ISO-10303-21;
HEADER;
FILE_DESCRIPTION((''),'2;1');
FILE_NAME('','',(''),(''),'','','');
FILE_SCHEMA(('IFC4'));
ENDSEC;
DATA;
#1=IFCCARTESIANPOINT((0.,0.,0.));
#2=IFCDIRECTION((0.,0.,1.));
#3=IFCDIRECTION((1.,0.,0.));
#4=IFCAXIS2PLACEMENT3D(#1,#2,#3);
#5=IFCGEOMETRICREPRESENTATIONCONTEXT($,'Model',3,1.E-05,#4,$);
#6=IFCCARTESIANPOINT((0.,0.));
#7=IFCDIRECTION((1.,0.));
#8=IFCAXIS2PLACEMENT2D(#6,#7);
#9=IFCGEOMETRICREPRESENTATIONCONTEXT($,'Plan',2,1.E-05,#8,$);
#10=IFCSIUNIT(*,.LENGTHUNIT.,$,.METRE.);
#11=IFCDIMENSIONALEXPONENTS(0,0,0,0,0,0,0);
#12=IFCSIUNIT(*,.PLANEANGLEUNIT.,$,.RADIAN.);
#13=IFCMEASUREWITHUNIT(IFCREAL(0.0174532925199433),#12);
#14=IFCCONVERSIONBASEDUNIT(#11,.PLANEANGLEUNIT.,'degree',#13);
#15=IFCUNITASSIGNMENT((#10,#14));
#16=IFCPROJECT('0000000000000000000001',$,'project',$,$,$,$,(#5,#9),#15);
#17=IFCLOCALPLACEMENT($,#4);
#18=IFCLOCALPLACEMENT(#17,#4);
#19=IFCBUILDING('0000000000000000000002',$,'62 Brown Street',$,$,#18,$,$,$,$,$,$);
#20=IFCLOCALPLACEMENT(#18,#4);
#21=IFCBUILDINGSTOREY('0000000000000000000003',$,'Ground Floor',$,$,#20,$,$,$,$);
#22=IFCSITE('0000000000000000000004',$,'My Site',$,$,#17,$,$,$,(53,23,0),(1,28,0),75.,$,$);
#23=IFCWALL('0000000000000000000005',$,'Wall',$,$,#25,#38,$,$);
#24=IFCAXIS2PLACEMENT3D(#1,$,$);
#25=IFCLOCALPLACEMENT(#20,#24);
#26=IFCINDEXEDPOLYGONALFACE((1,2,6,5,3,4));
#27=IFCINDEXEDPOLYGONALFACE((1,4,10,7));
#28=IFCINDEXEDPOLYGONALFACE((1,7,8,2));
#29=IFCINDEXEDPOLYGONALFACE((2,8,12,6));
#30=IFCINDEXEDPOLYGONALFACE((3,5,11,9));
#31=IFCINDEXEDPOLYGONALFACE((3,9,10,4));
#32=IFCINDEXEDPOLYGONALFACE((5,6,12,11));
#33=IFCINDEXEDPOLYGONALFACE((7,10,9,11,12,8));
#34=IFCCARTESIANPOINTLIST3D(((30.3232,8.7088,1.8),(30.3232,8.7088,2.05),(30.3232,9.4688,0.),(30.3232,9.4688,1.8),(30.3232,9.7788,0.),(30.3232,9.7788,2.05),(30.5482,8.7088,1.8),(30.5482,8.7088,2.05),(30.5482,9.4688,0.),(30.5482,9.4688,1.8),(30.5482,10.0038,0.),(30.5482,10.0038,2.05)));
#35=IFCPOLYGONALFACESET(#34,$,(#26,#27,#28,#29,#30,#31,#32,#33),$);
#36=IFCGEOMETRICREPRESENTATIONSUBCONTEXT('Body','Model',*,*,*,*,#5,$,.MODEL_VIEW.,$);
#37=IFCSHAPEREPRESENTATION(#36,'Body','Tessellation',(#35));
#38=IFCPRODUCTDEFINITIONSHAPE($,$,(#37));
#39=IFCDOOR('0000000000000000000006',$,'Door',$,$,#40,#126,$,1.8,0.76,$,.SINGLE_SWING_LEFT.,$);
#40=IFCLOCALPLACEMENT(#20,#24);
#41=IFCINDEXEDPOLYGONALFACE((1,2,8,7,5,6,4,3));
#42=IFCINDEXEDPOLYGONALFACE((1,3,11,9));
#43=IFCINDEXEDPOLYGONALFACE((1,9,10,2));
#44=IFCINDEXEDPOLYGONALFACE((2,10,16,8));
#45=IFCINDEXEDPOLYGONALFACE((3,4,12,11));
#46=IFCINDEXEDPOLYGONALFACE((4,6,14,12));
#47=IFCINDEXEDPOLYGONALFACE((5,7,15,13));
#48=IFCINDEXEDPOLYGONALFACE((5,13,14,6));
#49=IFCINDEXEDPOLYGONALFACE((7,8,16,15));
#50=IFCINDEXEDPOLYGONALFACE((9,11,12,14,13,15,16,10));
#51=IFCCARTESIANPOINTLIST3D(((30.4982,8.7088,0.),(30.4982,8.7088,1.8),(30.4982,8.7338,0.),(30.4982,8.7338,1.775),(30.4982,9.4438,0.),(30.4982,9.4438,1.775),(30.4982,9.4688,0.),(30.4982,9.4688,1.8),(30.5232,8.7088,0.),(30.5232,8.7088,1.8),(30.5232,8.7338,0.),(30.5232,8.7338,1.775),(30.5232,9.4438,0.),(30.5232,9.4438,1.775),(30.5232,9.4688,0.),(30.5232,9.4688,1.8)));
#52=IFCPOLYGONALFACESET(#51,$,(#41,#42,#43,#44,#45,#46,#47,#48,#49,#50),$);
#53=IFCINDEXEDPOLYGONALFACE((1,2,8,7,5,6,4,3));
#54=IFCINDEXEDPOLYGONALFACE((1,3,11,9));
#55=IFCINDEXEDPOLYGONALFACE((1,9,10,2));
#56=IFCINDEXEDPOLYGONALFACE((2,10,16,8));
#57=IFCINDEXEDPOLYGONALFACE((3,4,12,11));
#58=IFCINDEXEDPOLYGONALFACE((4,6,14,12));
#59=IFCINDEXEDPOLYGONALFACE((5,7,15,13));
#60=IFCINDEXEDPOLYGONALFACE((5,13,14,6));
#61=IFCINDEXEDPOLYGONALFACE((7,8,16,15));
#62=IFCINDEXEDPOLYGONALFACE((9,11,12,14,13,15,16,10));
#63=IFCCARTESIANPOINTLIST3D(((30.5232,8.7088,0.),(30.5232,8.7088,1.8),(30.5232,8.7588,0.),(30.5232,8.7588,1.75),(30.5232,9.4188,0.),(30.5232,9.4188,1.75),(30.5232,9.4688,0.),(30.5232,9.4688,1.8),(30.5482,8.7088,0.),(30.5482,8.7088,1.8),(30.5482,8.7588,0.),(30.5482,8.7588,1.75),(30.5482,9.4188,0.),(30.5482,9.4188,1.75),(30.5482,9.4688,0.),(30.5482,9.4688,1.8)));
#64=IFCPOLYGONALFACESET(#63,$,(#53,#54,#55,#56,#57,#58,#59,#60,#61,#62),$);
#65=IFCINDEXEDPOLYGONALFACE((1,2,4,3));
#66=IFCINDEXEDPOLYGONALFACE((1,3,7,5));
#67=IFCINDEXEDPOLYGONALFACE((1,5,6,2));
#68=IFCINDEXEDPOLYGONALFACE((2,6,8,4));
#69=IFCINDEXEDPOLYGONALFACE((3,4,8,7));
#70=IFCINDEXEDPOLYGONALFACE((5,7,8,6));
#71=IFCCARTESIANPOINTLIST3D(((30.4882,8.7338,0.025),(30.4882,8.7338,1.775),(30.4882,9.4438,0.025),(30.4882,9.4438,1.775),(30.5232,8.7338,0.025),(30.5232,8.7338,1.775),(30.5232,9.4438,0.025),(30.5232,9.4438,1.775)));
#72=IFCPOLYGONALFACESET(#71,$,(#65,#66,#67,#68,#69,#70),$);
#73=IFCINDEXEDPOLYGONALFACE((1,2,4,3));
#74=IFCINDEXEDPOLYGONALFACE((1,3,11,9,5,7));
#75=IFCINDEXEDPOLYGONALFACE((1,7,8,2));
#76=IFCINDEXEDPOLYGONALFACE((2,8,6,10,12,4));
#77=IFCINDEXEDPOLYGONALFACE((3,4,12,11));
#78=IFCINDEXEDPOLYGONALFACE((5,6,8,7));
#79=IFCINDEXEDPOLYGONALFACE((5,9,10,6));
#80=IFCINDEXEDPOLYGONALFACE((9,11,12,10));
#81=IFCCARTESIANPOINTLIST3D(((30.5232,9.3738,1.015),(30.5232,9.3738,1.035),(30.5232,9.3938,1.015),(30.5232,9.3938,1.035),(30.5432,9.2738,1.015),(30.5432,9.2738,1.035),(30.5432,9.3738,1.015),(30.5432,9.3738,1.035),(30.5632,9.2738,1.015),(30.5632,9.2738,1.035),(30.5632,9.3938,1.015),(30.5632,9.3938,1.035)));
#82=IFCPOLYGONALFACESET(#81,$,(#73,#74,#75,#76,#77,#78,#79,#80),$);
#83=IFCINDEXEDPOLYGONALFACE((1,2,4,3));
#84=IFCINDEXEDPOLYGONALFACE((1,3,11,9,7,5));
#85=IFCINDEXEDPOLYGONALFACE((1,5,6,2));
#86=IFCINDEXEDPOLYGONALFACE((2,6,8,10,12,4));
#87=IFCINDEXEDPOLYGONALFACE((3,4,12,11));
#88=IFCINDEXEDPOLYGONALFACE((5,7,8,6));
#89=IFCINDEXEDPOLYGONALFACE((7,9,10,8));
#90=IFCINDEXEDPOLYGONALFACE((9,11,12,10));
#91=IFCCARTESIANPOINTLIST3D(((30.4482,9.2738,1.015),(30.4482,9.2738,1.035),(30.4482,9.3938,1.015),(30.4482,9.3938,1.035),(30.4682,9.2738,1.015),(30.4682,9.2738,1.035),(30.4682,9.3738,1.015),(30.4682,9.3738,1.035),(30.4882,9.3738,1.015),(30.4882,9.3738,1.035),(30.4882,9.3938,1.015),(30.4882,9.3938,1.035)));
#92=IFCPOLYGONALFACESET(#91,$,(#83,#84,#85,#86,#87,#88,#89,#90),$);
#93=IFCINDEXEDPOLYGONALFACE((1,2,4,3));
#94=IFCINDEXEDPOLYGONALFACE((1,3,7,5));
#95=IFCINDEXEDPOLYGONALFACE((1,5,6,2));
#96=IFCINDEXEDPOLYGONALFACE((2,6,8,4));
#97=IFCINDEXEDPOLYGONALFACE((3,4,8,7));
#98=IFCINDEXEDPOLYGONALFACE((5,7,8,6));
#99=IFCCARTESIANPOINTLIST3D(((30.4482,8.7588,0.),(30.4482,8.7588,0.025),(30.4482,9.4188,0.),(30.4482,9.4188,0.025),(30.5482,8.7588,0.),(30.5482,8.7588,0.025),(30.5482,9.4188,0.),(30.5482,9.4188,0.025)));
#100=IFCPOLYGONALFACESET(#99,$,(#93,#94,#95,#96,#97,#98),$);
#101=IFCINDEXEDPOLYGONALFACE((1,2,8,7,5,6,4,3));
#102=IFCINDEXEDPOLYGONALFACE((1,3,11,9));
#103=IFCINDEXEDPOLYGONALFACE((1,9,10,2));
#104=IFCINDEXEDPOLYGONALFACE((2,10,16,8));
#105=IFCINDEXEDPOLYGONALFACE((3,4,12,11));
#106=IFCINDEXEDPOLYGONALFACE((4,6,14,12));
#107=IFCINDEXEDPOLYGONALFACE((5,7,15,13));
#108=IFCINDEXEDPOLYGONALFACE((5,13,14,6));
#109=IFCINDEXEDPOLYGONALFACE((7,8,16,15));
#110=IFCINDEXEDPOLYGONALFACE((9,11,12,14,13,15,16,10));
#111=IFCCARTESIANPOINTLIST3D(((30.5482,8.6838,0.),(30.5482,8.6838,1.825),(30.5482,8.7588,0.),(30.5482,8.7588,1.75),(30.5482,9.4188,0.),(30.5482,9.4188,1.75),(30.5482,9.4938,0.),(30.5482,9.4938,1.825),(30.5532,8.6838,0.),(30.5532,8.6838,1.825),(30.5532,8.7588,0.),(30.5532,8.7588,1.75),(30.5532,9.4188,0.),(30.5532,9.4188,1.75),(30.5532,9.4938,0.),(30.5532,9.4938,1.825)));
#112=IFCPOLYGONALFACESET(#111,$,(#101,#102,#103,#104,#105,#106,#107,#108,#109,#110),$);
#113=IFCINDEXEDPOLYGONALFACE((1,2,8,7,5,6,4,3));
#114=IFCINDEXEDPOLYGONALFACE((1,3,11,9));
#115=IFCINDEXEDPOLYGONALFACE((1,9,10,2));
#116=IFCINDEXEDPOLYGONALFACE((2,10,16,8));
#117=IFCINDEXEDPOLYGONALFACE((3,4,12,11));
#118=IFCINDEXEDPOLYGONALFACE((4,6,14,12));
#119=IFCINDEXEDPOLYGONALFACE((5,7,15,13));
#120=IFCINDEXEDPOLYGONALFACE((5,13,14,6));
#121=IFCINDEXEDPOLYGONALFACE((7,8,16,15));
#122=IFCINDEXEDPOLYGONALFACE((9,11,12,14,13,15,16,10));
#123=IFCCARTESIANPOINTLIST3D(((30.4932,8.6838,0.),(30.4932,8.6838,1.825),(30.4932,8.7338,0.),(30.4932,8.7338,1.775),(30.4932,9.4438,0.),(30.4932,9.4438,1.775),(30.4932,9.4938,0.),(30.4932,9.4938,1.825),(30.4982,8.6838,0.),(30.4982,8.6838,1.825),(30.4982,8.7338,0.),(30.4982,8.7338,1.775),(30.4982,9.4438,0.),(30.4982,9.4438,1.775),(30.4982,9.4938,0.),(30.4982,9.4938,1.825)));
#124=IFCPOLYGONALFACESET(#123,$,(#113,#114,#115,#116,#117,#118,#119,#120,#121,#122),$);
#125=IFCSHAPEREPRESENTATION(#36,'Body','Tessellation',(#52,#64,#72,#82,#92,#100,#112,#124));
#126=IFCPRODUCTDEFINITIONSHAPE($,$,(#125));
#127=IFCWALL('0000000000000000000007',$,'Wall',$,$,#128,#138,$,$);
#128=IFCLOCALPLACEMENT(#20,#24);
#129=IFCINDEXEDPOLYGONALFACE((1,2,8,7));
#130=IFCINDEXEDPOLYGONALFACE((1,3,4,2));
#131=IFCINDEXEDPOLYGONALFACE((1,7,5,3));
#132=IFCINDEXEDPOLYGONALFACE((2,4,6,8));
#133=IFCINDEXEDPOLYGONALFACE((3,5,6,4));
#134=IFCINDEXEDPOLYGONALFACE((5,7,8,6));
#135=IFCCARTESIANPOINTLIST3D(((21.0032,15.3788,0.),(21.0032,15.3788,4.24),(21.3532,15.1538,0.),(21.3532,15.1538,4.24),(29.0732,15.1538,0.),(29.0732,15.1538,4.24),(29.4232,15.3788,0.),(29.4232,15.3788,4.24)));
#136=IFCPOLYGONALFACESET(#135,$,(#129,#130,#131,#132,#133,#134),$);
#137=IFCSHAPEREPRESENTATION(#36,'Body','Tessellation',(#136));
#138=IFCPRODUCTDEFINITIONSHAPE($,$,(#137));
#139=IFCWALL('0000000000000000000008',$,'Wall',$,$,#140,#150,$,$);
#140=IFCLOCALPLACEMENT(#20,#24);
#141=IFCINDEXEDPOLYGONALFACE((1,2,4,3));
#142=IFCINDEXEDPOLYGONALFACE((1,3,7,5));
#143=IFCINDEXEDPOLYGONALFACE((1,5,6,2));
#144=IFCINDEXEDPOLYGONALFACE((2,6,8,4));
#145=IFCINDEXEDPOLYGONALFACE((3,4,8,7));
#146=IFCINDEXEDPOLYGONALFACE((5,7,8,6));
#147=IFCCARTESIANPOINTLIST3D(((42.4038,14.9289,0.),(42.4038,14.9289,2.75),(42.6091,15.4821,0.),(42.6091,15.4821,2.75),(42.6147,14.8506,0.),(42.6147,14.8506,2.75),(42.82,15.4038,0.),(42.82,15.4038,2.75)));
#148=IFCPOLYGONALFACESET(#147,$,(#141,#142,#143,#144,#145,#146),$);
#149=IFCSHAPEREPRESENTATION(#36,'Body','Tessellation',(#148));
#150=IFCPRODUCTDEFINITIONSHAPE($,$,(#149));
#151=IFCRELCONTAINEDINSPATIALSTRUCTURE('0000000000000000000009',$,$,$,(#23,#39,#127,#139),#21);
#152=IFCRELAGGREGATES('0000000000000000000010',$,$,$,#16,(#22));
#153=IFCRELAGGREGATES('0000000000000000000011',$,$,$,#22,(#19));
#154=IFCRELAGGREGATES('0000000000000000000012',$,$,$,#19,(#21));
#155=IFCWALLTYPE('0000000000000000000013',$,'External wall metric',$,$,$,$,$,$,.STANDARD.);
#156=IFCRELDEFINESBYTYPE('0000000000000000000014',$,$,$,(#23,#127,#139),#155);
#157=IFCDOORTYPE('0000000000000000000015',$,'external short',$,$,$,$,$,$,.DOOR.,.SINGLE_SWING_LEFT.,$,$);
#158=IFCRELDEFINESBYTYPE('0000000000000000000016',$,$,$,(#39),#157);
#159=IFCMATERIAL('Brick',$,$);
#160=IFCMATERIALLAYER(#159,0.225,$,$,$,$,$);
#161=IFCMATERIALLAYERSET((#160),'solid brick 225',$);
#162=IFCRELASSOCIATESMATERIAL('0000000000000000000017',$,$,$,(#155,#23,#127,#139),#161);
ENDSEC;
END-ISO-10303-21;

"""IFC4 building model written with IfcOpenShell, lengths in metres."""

from ifc_helpers import new_model, entity, si_unit, converted_unit, frame, origin_with_axes, origin_2d_with_axis, place, context, subcontext, project, spatial, line, indexed_curve, outline, extrude, clip, halfspace, shape, source, transform, mapped, material, layer, layer_set, layer_usage, type_object, type_shapes, element, fill, save


model = new_model("IFC4")

# Units and contexts
model_context = context("Model", 3, precision=1e-05, world=origin_with_axes())
plan_context = context("Plan", 2, precision=1e-05, world=origin_2d_with_axis())
body_context_1 = subcontext(model_context, "Body", "Model", "MODEL_VIEW")
body_context_2 = subcontext(plan_context, "Body", "Plan", "PLAN_VIEW")
ifc_project = project(units=[si_unit("LENGTHUNIT", "METRE"), converted_unit("PLANEANGLEUNIT", "degree", entity("IfcReal", 0.0174532925199433), si_unit("PLANEANGLEUNIT", "RADIAN"), dimensions=[0, 0, 0, 0, 0, 0, 0])], contexts=[model_context, plan_context])

# Site, building, storey
site_placement = place(None, origin_with_axes())
site = spatial("IfcSite", under=ifc_project, at=site_placement, Name="My Site", RefLatitude=(53, 23, 0), RefLongitude=(1, 28, 0), RefElevation=75.0)
building_placement = place(site_placement, origin_with_axes())
building = spatial("IfcBuilding", under=site, at=building_placement, Name="62 Brown Street")
storey_placement = place(building_placement, origin_with_axes())
storey = spatial("IfcBuildingStorey", under=building, at=storey_placement, Name="Ground Floor")

# Shared definitions
ifc_material_1 = material(Name="Brick")
ifc_layer_1 = layer(ifc_material_1, 0.225)
ifc_layer_set_1 = layer_set([ifc_layer_1], Name="solid brick 225")
wall_type_1 = type_object("IfcWallType", Name="External wall metric", PredefinedType="STANDARD", material=ifc_layer_set_1)

# Wall, opening, door
ifc_layer_usage_1 = layer_usage(ifc_layer_set_1, "AXIS2", "POSITIVE", 0.0)
wall_1_placement = place(storey_placement, frame((30.5482, 8.7088, 0.0), z_axis=(0.0, 0.0, 1.0), x_axis=(0.0, 1.0, 0.0)))
wall_1 = element("IfcWall", 1, at=wall_1_placement, inside=storey, type_object=wall_type_1, material=ifc_layer_usage_1, Name="Wall", context=body_context_1, shape_type="Clipping", body=[
    clip(extrude(outline(indexed_curve([(0.0, 0.0), (0.0, 0.225), (1.295, 0.225), (1.295, 0.0), (0.0, 0.0)], self_intersect=False)), origin_with_axes(), (0.0, 0.0, 1.0), 2.05), halfspace(frame((1.295, 0.0, 0.0), z_axis=(0.450001, 0.450001, 0.0), x_axis=(-0.225, 0.225, 0.0)), False)),
])
shared_shape_1 = source(origin_with_axes(), body_context_1, "Body", "SweptSolid", [
    extrude(outline(indexed_curve([(0.0, 0.0), (0.76, 0.0), (0.76, 1.8), (0.0, 1.8)], segments=[line(1, 2, 3, 4, 1)])), frame((0.0, -0.1, 0.0), z_axis=(0.0, -1.0, 0.0), x_axis=(1.0, 0.0, 0.0)), (0.0, 0.0, -1.0), 0.425),
])
opening_1_placement = place(wall_1_placement, frame((0.0, 0.0, 0.0), z_axis=(0.0, 0.0, 1.0), x_axis=(1.0, 0.0, 0.0)))
opening_1 = element("IfcOpeningElement", 2, at=opening_1_placement, cuts=wall_1, PredefinedType="OPENING", context=body_context_1, shape_type="MappedRepresentation", body=[
    mapped(shared_shape_1, transform((0.0, 0.0, 0.0), x_axis=(1.0, 0.0, 0.0), y_axis=(0.0, 1.0, 0.0), z_axis=(0.0, 0.0, 1.0), scale=1.0)),
])
door_type_1 = type_object("IfcDoorType", Name="external short", OperationType="SINGLE_SWING_LEFT", PredefinedType="DOOR")
shared_shape_2 = source(origin_with_axes(), body_context_1, "Body", "SweptSolid", [
    extrude(outline(indexed_curve([(0.0, 0.0), (0.0, 1.8), (0.76, 1.8), (0.76, 0.0), (0.735, 0.0), (0.735, 1.775), (0.025, 1.775), (0.025, 0.0)], segments=[line(1, 2, 3, 4, 5, 6, 7, 8, 1)])), frame((0.0, 0.025, 0.0), z_axis=(0.0, -1.0, 0.0), x_axis=(1.0, 0.0, 0.0)), (0.0, 0.0, -1.0), 0.025),
    extrude(outline(indexed_curve([(0.0, 0.0), (0.0, 1.8), (0.76, 1.8), (0.76, 0.0), (0.71, 0.0), (0.71, 1.75), (0.05, 1.75), (0.05, 0.0)], segments=[line(1, 2, 3, 4, 5, 6, 7, 8, 1)])), frame((0.0, 0.0, 0.0), z_axis=(0.0, -1.0, 0.0), x_axis=(1.0, 0.0, 0.0)), (0.0, 0.0, -1.0), 0.025),
    extrude(outline(indexed_curve([(0.0, 0.0), (0.71, 0.0), (0.71, 0.035), (0.0, 0.035)], segments=[line(1, 2, 3, 4, 1)])), frame((0.025, 0.025, 0.025), z_axis=(0.0, 0.0, 1.0), x_axis=(1.0, 0.0, 0.0)), (0.0, 0.0, 1.0), 1.75),
    extrude(outline(indexed_curve([(0.0, 0.0), (0.0, -0.04), (-0.12, -0.04), (-0.12, -0.02), (-0.02, -0.02), (-0.02, 0.0)], segments=[line(1, 2, 3, 4, 5, 6, 1)])), frame((0.685, 0.025, 1.015), z_axis=(0.0, 0.0, 1.0), x_axis=(1.0, 0.0, 0.0)), (0.0, 0.0, 1.0), 0.02),
    extrude(outline(indexed_curve([(0.0, 0.0), (0.0, 0.04), (-0.12, 0.04), (-0.12, 0.02), (-0.02, 0.02), (-0.02, 0.0)], segments=[line(1, 2, 3, 4, 5, 6, 1)])), frame((0.685, 0.06, 1.015), z_axis=(0.0, 0.0, 1.0), x_axis=(1.0, 0.0, 0.0)), (0.0, 0.0, 1.0), 0.02),
    extrude(outline(indexed_curve([(0.0, 0.0), (0.66, 0.0), (0.66, 0.1), (0.0, 0.1)], segments=[line(1, 2, 3, 4, 1)])), frame((0.05, 0.0, 0.0), z_axis=(0.0, 0.0, 1.0), x_axis=(1.0, 0.0, 0.0)), (0.0, 0.0, 1.0), 0.025),
    extrude(outline(indexed_curve([(0.0, 0.0), (0.0, 1.825), (0.81, 1.825), (0.81, 0.0), (0.735, 0.0), (0.735, 1.75), (0.075, 1.75), (0.075, 0.0)], segments=[line(1, 2, 3, 4, 5, 6, 7, 8, 1)])), frame((-0.025, -0.005, 0.0), z_axis=(0.0, -1.0, 0.0), x_axis=(1.0, 0.0, 0.0)), (0.0, 0.0, -1.0), 0.005),
    extrude(outline(indexed_curve([(0.0, 0.0), (0.0, 1.825), (0.81, 1.825), (0.81, 0.0), (0.76, 0.0), (0.76, 1.775), (0.05, 1.775), (0.05, 0.0)], segments=[line(1, 2, 3, 4, 5, 6, 7, 8, 1)])), frame((-0.025, 0.05, 0.0), z_axis=(0.0, -1.0, 0.0), x_axis=(1.0, 0.0, 0.0)), (0.0, 0.0, -1.0), 0.005),
])
shared_shape_3 = source(origin_with_axes(), body_context_2, "Body", "Curve2D", [
    entity("IfcIndexedPolyCurve", entity("IfcCartesianPointList2D", [[0.0, 0.0], [0.0, 0.05], [0.025, 0.05], [0.025, 0.025], [0.05, 0.025], [0.05, 0.0]]), [entity("IfcLineIndex", [1, 2, 3, 4, 5, 6, 1])]),
    entity("IfcIndexedPolyCurve", entity("IfcCartesianPointList2D", [[0.76, 0.0], [0.76, 0.05], [0.735, 0.05], [0.735, 0.025], [0.71, 0.025], [0.71, 0.0]]), [entity("IfcLineIndex", [1, 2, 3, 4, 5, 6, 1])]),
    entity("IfcTrimmedCurve", entity("IfcEllipse", entity("IfcAxis2Placement2D", entity("IfcCartesianPoint", [0.06, 0.05]), entity("IfcDirection", [1.0, 0.0])), 0.675, 0.71), [entity("IfcCartesianPoint", [0.735, 0.05])], [entity("IfcCartesianPoint", [0.06, 0.76])], True, "CARTESIAN"),
    entity("IfcIndexedPolyCurve", entity("IfcCartesianPointList2D", [[0.025, 0.05], [0.06, 0.05], [0.06, 0.76], [0.025, 0.76]]), [entity("IfcLineIndex", [1, 2, 3, 4, 1])]),
])
type_shapes(door_type_1, [shared_shape_2, shared_shape_3])
door_1_placement = place(opening_1_placement, frame((0.0, 0.0, 0.0), z_axis=(0.0, 0.0, 1.0), x_axis=(1.0, 0.0, 0.0)))
door_1 = element("IfcDoor", 3, at=door_1_placement, inside=storey, type_object=door_type_1, Name="Door", OperationType="SINGLE_SWING_LEFT", OverallHeight=1.8, OverallWidth=0.76, shapes=[
    shape(body_context_1, "Body", "MappedRepresentation", [mapped(shared_shape_2, transform((0.0, 0.0, 0.0), x_axis=(1.0, 0.0, 0.0), y_axis=(0.0, 1.0, 0.0), z_axis=(0.0, 0.0, 1.0), scale=1.0))]),
    shape(body_context_2, "Body", "MappedRepresentation", [mapped(shared_shape_3, transform((0.0, 0.0, 0.0), x_axis=(1.0, 0.0, 0.0), y_axis=(0.0, 1.0, 0.0), z_axis=(0.0, 0.0, 1.0), scale=1.0))]),
])
fill(opening_1, door_1)

# Walls
ifc_layer_usage_2 = layer_usage(ifc_layer_set_1, "AXIS2", "POSITIVE", 0.0)
wall_2_placement = place(storey_placement, frame((29.4232, 15.3788, 0.0), z_axis=(0.0, 0.0, 1.0), x_axis=(-1.0, 0.0, 0.0)))
element("IfcWall", 4, at=wall_2_placement, inside=storey, type_object=wall_type_1, material=ifc_layer_usage_2, Name="Wall", context=body_context_1, shape_type="Clipping", body=[
    clip(clip(extrude(outline(indexed_curve([(0.0, 0.0), (0.0, 0.225), (8.42, 0.225), (8.42, 0.0), (0.0, 0.0)], self_intersect=False)), origin_with_axes(), (0.0, 0.0, 1.0), 4.24), halfspace(frame((8.42, 0.0, 0.0), z_axis=(0.540756, 0.841179, 0.0), x_axis=(-0.841179, 0.540756, 0.0)), False)), halfspace(frame((0.0, 0.0, 0.0), z_axis=(-0.540758, 0.841178, 0.0), x_axis=(0.841178, 0.540758, 0.0)), False)),
])
ifc_layer_usage_3 = layer_usage(ifc_layer_set_1, "AXIS2", "POSITIVE", 0.0)
wall_3_placement = place(storey_placement, frame((42.6147, 14.8506, 0.0), z_axis=(0.0, 0.0, 1.0), x_axis=(0.347944, 0.937515, 0.0)))
element("IfcWall", 5, at=wall_3_placement, inside=storey, type_object=wall_type_1, material=ifc_layer_usage_3, Name="Wall", context=body_context_1, shape_type="SweptSolid", body=[
    extrude(outline(indexed_curve([(0.0, 0.0), (0.0, 0.225), (0.5901, 0.225), (0.5901, 0.0), (0.0, 0.0)], self_intersect=False)), origin_with_axes(), (0.0, 0.0, 1.0), 2.75),
])

save(model, "model.ifc")
